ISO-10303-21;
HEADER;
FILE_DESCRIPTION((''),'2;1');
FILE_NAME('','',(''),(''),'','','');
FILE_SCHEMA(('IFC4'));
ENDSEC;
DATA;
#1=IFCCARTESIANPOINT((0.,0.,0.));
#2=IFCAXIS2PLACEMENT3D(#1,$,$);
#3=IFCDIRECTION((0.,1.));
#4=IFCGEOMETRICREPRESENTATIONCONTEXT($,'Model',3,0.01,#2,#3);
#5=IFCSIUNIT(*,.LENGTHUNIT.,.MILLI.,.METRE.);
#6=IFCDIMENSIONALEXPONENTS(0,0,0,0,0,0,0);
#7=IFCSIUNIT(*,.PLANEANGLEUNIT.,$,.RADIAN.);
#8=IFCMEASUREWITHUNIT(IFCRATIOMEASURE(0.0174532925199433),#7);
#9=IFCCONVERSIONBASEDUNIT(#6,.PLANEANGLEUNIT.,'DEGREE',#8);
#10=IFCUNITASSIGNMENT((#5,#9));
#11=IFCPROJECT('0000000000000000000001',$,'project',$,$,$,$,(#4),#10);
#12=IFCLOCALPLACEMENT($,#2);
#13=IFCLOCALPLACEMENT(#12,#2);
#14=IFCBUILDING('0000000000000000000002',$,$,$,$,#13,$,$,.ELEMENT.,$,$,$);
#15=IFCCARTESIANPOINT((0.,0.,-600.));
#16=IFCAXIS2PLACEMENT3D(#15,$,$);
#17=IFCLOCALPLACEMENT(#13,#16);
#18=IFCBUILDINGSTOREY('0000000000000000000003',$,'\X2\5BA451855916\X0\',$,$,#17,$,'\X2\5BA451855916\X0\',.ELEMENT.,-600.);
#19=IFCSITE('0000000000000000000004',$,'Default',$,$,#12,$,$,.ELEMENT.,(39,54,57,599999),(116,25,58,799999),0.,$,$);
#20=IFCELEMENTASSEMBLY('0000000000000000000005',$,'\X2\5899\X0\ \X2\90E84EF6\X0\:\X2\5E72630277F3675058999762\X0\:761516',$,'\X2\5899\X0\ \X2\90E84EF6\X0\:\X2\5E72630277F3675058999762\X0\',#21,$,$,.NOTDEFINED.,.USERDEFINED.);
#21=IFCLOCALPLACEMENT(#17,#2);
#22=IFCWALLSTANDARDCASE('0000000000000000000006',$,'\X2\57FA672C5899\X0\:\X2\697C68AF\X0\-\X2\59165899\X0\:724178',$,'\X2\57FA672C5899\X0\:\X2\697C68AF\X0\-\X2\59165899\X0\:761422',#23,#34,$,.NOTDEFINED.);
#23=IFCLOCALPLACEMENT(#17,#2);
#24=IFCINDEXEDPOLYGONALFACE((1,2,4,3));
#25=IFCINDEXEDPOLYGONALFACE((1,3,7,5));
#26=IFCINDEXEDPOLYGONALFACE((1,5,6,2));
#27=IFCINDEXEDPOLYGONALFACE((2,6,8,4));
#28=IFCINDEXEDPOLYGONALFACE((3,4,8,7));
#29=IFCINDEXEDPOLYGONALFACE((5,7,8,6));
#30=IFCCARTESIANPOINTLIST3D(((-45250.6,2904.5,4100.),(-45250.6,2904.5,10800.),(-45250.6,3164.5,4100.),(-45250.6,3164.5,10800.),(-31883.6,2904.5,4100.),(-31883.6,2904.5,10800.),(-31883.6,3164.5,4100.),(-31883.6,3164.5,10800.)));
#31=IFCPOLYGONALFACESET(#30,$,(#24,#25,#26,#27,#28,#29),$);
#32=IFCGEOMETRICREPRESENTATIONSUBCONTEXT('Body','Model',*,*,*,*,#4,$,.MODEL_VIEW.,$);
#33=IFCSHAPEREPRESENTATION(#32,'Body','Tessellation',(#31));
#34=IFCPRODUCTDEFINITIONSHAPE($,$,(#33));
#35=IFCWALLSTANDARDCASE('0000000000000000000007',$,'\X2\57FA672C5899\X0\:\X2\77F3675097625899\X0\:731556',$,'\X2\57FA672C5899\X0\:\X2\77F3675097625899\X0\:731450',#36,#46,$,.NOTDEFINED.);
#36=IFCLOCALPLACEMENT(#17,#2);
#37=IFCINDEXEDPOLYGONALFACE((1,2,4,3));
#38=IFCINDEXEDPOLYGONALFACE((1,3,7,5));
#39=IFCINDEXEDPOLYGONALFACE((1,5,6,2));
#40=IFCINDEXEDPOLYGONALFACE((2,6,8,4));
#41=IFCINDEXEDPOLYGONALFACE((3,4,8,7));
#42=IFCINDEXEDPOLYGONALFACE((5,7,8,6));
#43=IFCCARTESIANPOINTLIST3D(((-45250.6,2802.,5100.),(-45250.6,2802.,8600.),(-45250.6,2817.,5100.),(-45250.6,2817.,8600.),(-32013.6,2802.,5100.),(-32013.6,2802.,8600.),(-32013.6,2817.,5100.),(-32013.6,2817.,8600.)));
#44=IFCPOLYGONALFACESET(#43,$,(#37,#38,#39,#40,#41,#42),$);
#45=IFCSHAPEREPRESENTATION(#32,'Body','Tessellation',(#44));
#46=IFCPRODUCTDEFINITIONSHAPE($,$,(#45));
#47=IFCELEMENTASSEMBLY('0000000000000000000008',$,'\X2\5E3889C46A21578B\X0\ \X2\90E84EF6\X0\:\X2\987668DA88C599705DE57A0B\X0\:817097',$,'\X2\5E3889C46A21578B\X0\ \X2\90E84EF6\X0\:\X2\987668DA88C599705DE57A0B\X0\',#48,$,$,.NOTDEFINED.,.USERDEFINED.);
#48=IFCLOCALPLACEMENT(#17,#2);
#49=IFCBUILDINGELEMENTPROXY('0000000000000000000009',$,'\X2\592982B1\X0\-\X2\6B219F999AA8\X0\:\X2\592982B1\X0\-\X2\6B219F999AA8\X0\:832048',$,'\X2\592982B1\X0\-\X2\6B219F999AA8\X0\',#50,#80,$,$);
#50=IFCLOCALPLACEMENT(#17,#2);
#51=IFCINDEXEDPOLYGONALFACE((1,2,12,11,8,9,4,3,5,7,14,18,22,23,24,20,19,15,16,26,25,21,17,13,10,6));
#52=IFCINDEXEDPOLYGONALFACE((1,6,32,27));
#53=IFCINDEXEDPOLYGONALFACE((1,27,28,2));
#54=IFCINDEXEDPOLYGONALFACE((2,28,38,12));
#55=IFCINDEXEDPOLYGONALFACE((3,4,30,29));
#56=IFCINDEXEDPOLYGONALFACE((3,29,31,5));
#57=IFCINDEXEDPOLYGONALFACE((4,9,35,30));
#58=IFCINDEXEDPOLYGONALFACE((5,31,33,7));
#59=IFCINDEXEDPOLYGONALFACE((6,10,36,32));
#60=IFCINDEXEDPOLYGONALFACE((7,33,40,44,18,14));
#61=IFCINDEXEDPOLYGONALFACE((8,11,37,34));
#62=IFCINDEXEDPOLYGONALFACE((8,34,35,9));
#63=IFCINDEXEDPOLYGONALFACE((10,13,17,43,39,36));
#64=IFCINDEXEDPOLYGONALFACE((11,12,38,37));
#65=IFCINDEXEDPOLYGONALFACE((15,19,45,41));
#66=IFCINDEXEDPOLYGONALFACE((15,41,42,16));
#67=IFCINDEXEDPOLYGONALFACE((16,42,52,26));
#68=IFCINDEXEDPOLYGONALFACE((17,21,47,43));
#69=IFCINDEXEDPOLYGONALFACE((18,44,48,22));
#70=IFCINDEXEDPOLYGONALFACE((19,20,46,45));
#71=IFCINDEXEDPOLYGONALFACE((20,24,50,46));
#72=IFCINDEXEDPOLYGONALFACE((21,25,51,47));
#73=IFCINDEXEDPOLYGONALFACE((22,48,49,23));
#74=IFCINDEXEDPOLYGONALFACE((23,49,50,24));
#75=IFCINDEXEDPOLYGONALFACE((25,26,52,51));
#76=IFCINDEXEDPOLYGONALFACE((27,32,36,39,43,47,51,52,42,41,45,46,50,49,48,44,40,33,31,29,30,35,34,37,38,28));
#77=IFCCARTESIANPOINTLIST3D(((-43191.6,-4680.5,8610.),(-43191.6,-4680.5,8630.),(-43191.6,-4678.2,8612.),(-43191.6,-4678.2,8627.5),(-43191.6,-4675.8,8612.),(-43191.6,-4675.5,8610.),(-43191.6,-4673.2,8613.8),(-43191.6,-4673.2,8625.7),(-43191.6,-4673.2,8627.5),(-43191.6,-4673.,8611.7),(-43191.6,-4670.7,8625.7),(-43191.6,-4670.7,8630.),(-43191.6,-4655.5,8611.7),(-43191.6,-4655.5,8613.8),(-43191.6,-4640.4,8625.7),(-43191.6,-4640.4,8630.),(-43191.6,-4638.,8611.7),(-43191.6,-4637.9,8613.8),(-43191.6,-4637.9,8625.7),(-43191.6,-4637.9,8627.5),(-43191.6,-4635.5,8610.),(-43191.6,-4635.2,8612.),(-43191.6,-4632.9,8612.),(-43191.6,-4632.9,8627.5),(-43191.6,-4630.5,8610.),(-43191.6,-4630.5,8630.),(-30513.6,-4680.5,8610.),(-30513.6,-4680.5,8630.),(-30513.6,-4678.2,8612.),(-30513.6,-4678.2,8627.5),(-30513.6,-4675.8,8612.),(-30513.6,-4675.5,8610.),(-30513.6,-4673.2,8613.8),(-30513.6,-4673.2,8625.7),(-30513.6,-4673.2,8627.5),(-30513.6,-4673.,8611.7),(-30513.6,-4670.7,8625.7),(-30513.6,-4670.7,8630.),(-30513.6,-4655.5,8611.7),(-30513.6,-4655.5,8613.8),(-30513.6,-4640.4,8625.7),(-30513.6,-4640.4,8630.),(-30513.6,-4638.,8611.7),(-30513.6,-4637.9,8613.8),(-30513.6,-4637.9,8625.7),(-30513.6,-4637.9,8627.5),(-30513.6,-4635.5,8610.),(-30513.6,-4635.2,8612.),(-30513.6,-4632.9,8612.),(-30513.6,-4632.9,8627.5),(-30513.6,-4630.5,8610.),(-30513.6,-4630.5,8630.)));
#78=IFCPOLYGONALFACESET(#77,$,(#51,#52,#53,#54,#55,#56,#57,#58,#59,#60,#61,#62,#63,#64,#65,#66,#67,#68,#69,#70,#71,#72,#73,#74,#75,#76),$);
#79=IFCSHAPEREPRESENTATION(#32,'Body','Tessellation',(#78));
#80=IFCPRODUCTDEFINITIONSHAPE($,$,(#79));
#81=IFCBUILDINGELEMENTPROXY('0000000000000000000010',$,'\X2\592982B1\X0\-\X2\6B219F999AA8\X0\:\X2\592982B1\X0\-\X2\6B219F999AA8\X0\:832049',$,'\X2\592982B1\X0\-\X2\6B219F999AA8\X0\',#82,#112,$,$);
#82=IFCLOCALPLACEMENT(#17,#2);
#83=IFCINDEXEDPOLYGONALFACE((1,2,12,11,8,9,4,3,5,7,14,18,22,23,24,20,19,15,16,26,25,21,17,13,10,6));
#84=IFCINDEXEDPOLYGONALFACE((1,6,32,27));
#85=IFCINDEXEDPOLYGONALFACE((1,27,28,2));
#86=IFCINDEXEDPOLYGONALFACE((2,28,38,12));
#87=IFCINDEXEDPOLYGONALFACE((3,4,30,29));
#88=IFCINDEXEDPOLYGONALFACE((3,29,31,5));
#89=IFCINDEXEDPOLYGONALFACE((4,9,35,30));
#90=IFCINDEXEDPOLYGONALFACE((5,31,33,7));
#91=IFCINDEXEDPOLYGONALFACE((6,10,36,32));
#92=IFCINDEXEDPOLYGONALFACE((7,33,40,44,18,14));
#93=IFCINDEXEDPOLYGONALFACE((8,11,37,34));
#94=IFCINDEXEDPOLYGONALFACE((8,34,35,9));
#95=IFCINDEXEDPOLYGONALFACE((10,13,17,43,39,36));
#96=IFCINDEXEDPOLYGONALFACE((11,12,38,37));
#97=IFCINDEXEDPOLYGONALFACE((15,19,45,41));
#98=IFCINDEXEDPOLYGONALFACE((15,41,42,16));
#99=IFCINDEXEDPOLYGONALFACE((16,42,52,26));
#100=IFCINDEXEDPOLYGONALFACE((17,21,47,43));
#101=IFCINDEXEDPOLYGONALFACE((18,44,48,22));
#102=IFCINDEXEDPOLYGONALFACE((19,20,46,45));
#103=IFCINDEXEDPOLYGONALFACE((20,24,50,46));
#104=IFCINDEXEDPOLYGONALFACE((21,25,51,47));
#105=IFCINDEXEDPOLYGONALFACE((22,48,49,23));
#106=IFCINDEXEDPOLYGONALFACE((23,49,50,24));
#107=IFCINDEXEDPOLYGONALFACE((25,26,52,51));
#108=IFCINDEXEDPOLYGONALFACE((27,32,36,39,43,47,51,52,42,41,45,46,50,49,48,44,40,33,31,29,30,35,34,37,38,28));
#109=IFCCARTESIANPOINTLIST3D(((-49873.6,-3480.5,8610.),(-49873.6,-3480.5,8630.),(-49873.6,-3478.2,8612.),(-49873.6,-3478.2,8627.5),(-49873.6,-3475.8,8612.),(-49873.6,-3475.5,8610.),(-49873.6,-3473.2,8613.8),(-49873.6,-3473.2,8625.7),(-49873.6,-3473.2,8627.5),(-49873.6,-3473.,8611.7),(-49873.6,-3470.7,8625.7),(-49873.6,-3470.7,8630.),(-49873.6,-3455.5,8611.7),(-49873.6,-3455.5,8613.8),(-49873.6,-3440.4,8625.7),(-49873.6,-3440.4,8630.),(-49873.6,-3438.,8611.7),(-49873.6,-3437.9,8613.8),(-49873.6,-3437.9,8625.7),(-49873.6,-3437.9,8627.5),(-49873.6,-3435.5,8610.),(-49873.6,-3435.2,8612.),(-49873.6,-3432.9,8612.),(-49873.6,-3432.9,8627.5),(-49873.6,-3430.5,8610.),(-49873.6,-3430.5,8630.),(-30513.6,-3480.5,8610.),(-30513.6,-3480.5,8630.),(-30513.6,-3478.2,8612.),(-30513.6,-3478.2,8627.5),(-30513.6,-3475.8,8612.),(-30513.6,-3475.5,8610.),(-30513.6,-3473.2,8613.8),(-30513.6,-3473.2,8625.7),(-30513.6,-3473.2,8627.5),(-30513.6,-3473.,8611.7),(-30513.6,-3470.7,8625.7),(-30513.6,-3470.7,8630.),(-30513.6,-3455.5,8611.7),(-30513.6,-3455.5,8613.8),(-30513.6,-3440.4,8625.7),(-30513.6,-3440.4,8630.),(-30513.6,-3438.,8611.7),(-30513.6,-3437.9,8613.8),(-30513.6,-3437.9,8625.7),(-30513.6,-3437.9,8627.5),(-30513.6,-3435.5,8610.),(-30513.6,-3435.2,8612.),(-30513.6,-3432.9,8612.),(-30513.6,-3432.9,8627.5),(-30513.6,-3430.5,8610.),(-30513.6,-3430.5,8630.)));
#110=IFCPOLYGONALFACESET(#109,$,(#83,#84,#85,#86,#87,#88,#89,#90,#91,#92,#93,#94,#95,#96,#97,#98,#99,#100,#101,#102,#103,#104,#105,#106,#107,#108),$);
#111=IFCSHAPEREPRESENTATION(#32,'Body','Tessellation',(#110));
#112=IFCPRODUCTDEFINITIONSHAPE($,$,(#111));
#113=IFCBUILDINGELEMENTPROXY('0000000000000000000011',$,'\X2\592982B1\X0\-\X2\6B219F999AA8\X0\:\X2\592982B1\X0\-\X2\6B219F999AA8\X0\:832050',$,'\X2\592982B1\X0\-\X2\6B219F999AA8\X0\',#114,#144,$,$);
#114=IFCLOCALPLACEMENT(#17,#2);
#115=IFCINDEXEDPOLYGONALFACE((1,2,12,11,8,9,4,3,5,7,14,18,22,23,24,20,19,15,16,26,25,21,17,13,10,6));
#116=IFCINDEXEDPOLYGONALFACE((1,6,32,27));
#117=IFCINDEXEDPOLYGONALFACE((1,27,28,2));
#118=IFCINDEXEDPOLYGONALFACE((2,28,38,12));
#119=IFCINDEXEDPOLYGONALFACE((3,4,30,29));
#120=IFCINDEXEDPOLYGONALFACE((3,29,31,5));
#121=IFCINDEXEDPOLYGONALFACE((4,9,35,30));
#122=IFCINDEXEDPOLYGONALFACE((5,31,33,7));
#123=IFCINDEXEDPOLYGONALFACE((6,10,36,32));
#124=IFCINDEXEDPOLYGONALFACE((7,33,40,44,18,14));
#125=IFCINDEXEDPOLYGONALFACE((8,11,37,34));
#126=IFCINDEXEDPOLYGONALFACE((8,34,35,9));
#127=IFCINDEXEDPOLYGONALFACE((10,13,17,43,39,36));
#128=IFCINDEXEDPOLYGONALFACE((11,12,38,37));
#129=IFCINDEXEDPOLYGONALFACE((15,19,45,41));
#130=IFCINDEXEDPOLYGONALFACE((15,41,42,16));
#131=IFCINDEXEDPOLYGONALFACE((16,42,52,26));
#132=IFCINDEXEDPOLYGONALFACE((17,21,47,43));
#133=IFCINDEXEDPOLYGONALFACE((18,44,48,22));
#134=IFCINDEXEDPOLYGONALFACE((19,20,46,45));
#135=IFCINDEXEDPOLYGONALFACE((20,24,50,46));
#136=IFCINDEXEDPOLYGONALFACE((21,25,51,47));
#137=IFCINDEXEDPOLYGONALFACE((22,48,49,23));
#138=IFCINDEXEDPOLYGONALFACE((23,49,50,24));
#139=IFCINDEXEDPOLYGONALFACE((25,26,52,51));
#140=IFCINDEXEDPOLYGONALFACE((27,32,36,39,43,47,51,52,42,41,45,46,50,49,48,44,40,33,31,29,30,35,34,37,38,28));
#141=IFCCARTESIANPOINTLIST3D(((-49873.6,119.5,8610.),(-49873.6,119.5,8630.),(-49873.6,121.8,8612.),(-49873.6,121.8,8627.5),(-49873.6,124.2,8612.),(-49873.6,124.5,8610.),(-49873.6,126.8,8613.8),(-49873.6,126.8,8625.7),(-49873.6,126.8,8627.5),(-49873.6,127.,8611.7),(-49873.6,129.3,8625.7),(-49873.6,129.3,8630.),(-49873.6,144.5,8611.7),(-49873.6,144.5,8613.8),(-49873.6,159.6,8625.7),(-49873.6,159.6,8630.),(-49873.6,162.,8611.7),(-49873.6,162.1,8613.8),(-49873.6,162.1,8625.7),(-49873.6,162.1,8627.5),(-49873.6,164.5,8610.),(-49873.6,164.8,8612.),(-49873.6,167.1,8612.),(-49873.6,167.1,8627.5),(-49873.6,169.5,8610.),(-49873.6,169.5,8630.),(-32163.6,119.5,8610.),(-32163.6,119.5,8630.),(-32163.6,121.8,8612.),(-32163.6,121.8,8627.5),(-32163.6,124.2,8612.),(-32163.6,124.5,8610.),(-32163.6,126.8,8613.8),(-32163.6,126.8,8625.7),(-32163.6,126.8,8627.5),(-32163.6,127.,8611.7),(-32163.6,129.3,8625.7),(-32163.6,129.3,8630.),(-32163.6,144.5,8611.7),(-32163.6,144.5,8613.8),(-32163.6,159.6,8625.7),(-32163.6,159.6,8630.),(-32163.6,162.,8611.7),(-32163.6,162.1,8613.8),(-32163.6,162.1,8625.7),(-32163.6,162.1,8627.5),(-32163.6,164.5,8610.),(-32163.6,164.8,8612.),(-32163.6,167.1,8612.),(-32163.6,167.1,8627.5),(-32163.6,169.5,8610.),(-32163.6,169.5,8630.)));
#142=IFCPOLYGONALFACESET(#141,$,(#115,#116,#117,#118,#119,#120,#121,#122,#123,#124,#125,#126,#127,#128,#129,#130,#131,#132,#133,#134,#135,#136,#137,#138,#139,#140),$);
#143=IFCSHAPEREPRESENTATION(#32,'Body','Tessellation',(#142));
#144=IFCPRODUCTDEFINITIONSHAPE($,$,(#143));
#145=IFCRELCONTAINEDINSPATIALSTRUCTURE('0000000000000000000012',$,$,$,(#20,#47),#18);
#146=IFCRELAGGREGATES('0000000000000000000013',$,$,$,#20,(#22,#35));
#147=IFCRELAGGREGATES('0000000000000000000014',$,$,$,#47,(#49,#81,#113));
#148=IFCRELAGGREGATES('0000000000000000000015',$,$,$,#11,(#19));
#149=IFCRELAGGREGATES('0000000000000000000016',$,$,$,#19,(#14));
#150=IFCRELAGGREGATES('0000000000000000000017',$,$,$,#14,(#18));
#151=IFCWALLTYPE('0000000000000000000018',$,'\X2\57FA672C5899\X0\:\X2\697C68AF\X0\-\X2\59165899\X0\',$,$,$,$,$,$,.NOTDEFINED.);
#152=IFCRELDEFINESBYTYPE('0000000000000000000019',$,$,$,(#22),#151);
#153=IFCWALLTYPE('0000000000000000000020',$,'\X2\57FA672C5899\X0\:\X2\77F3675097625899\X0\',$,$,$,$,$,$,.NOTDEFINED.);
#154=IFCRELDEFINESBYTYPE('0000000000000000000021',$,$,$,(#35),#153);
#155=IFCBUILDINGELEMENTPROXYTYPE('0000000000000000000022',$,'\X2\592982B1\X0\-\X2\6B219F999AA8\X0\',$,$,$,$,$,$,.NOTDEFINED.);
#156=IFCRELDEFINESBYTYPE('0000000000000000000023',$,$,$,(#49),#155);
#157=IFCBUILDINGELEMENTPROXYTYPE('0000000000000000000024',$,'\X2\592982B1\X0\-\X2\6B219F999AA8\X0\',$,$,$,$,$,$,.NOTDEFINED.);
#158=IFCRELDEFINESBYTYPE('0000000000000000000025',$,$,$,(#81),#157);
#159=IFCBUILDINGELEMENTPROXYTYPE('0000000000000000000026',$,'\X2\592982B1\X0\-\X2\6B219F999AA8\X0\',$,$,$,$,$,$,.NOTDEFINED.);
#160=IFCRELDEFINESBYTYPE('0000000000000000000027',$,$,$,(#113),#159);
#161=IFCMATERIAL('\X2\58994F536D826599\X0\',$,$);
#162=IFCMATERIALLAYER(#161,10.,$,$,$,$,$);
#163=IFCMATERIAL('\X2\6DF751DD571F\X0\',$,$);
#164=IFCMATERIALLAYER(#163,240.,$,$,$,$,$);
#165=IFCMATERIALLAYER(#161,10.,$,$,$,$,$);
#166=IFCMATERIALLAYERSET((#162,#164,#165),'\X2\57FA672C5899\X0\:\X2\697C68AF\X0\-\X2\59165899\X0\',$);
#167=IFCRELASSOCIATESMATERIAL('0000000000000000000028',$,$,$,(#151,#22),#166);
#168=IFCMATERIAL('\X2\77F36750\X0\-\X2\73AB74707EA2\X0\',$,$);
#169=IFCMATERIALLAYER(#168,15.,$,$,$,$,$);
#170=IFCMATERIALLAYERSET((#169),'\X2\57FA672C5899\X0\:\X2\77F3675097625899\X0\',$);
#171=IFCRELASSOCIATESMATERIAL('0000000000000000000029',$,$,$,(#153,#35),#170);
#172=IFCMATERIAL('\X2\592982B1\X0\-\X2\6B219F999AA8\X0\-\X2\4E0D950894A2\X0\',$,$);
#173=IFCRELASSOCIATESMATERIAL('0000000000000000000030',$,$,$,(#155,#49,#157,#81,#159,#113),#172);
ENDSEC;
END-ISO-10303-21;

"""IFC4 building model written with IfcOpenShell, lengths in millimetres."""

from ifc_helpers import new_model, entity, si_unit, converted_unit, direction, frame, frame_2d, origin, place, context, subcontext, project, spatial, polyline, rectangle, outline, extrude, source, transform, mapped, material, layer, layer_set, layer_usage, type_object, type_shapes, element, aggregate, save


model = new_model("IFC4")

# Units and contexts
model_context = context("Model", 3, precision=0.01, world=origin(), true_north=direction((0.0, 1.0)))
body_context = subcontext(model_context, "Body", "Model", "MODEL_VIEW")
ifc_project = project(units=[si_unit("LENGTHUNIT", "METRE", prefix="MILLI"), converted_unit("PLANEANGLEUNIT", "DEGREE", entity("IfcRatioMeasure", 0.0174532925199433), si_unit("PLANEANGLEUNIT", "RADIAN"), dimensions=[0, 0, 0, 0, 0, 0, 0])], contexts=[model_context])

# Site, building, storey
site_placement = place(None, origin())
site = spatial("IfcSite", under=ifc_project, at=site_placement, Name="Default", CompositionType="ELEMENT", RefLatitude=(39, 54, 57, 599999), RefLongitude=(116, 25, 58, 799999), RefElevation=0.0)
building_placement = place(site_placement, origin())
building = spatial("IfcBuilding", under=site, at=building_placement, CompositionType="ELEMENT")
storey_placement = place(building_placement, frame((0.0, 0.0, -600.0)))
storey = spatial("IfcBuildingStorey", under=building, at=storey_placement, Name="室内外", LongName="室内外", CompositionType="ELEMENT", Elevation=-600.0)

# Element assembly, walls
assembly_1_placement = place(storey_placement, origin())
assembly_1 = element("IfcElementAssembly", 1, at=assembly_1_placement, inside=storey, Name="墙 部件:干挂石材墙面:761516", ObjectType="墙 部件:干挂石材墙面", AssemblyPlace="NOTDEFINED", PredefinedType="USERDEFINED")
ifc_material_1 = material(Name="墙体涂料")
ifc_layer_1 = layer(ifc_material_1, 10.0)
ifc_material_2 = material(Name="混凝土")
ifc_layer_2 = layer(ifc_material_2, 240.0)
ifc_layer_3 = layer(ifc_material_1, 10.0)
ifc_layer_set_1 = layer_set([ifc_layer_1, ifc_layer_2, ifc_layer_3], Name="基本墙:楼梯-外墙")
ifc_layer_usage_1 = layer_usage(ifc_layer_set_1, "AXIS2", "NEGATIVE", 130.0)
wall_type_1 = type_object("IfcWallType", Name="基本墙:楼梯-外墙", PredefinedType="NOTDEFINED", material=ifc_layer_set_1)
wall_1_placement = place(assembly_1_placement, frame((-45250.6, 3034.5, 4100.0)))
wall_1 = element("IfcWallStandardCase", 2, at=wall_1_placement, type_object=wall_type_1, material=ifc_layer_usage_1, Name="基本墙:楼梯-外墙:724178", ObjectType="基本墙:楼梯-外墙:761422", PredefinedType="NOTDEFINED", context=body_context, shape_type="SweptSolid", body=[
    extrude(rectangle(XDim=13367.0, YDim=260.0, at=frame_2d((6683.5, 0.0), x_axis=(-1.0, 0.0))), origin(), (0.0, 0.0, 1.0), 6700.0),
])
ifc_material_3 = material(Name="石材-玫瑰红")
ifc_layer_4 = layer(ifc_material_3, 15.0)
ifc_layer_set_2 = layer_set([ifc_layer_4], Name="基本墙:石材面墙")
ifc_layer_usage_2 = layer_usage(ifc_layer_set_2, "AXIS2", "POSITIVE", -7.5)
wall_type_2 = type_object("IfcWallType", Name="基本墙:石材面墙", PredefinedType="NOTDEFINED", material=ifc_layer_set_2)
wall_2_placement = place(assembly_1_placement, frame((-45250.6, 2809.5, 5100.0)))
wall_2 = element("IfcWallStandardCase", 3, at=wall_2_placement, type_object=wall_type_2, material=ifc_layer_usage_2, Name="基本墙:石材面墙:731556", ObjectType="基本墙:石材面墙:731450", PredefinedType="NOTDEFINED", context=body_context, shape_type="SweptSolid", body=[
    extrude(rectangle(XDim=13237.0, YDim=15.0, at=frame_2d((6618.5, 0.0), x_axis=(-1.0, 0.0))), origin(), (0.0, 0.0, 1.0), 3500.0),
])
aggregate(assembly_1, [wall_1, wall_2])

# Element assembly, building element proxies
assembly_2_placement = place(storey_placement, origin())
assembly_2 = element("IfcElementAssembly", 4, at=assembly_2_placement, inside=storey, Name="常规模型 部件:顶棚装饰工程:817097", ObjectType="常规模型 部件:顶棚装饰工程", AssemblyPlace="NOTDEFINED", PredefinedType="USERDEFINED")
ifc_material_4 = material(Name="天花-次龙骨-不锈钢")
building_element_proxy_type_1 = type_object("IfcBuildingElementProxyType", Name="天花-次龙骨", PredefinedType="NOTDEFINED", material=ifc_material_4)
shared_shape_1 = source(origin(), body_context, "Body", "SweptSolid", [
    extrude(outline(polyline([(-25.0, -9.1), (-20.0, -9.1), (-17.5, -7.4), (0.0, -7.4), (17.5, -7.4), (20.0, -9.1), (25.0, -9.1), (25.0, 10.9), (15.1, 10.9), (15.1, 6.6), (17.6, 6.6), (17.6, 8.4), (22.6, 8.4), (22.6, -7.1), (20.3, -7.1), (17.6, -5.3), (0.0, -5.3), (-17.6, -5.3), (-20.3, -7.1), (-22.6, -7.1), (-22.6, 8.4), (-17.6, 8.4), (-17.6, 6.6), (-15.1, 6.6), (-15.1, 10.9), (-25.0, 10.9), (-25.0, -9.1)])), frame((0.0, 0.0, -0.9), z_axis=(1.0, 0.0, 0.0), x_axis=(0.0, 1.0, 0.0)), (0.0, 0.0, 1.0), 12678.0),
])
type_shapes(building_element_proxy_type_1, [shared_shape_1])
proxy_1_placement = place(assembly_2_placement, frame((-43191.6, -4655.5, 8620.0)))
proxy_1 = element("IfcBuildingElementProxy", 5, at=proxy_1_placement, type_object=building_element_proxy_type_1, material=ifc_material_4, Name="天花-次龙骨:天花-次龙骨:832048", ObjectType="天花-次龙骨", context=body_context, shape_type="MappedRepresentation", body=[
    mapped(shared_shape_1, transform((0.0, 0.0, 0.0), scale=1.0)),
])
building_element_proxy_type_2 = type_object("IfcBuildingElementProxyType", Name="天花-次龙骨", PredefinedType="NOTDEFINED", material=ifc_material_4)
shared_shape_2 = source(origin(), body_context, "Body", "SweptSolid", [
    extrude(outline(polyline([(-25.0, -9.1), (-20.0, -9.1), (-17.5, -7.4), (0.0, -7.4), (17.5, -7.4), (20.0, -9.1), (25.0, -9.1), (25.0, 10.9), (15.1, 10.9), (15.1, 6.6), (17.6, 6.6), (17.6, 8.4), (22.6, 8.4), (22.6, -7.1), (20.3, -7.1), (17.6, -5.3), (0.0, -5.3), (-17.6, -5.3), (-20.3, -7.1), (-22.6, -7.1), (-22.6, 8.4), (-17.6, 8.4), (-17.6, 6.6), (-15.1, 6.6), (-15.1, 10.9), (-25.0, 10.9), (-25.0, -9.1)])), frame((0.0, 0.0, -0.9), z_axis=(1.0, 0.0, 0.0), x_axis=(0.0, 1.0, 0.0)), (0.0, 0.0, 1.0), 19360.0),
])
type_shapes(building_element_proxy_type_2, [shared_shape_2])
proxy_2_placement = place(assembly_2_placement, frame((-49873.6, -3455.5, 8620.0)))
proxy_2 = element("IfcBuildingElementProxy", 6, at=proxy_2_placement, type_object=building_element_proxy_type_2, material=ifc_material_4, Name="天花-次龙骨:天花-次龙骨:832049", ObjectType="天花-次龙骨", context=body_context, shape_type="MappedRepresentation", body=[
    mapped(shared_shape_2, transform((0.0, 0.0, 0.0), scale=1.0)),
])
building_element_proxy_type_3 = type_object("IfcBuildingElementProxyType", Name="天花-次龙骨", PredefinedType="NOTDEFINED", material=ifc_material_4)
shared_shape_3 = source(origin(), body_context, "Body", "SweptSolid", [
    extrude(outline(polyline([(-25.0, -9.1), (-20.0, -9.1), (-17.5, -7.4), (0.0, -7.4), (17.5, -7.4), (20.0, -9.1), (25.0, -9.1), (25.0, 10.9), (15.1, 10.9), (15.1, 6.6), (17.6, 6.6), (17.6, 8.4), (22.6, 8.4), (22.6, -7.1), (20.3, -7.1), (17.6, -5.3), (0.0, -5.3), (-17.6, -5.3), (-20.3, -7.1), (-22.6, -7.1), (-22.6, 8.4), (-17.6, 8.4), (-17.6, 6.6), (-15.1, 6.6), (-15.1, 10.9), (-25.0, 10.9), (-25.0, -9.1)])), frame((0.0, 0.0, -0.9), z_axis=(1.0, 0.0, 0.0), x_axis=(0.0, 1.0, 0.0)), (0.0, 0.0, 1.0), 17710.0),
])
type_shapes(building_element_proxy_type_3, [shared_shape_3])
proxy_3_placement = place(assembly_2_placement, frame((-49873.6, 144.5, 8620.0)))
proxy_3 = element("IfcBuildingElementProxy", 7, at=proxy_3_placement, type_object=building_element_proxy_type_3, material=ifc_material_4, Name="天花-次龙骨:天花-次龙骨:832050", ObjectType="天花-次龙骨", context=body_context, shape_type="MappedRepresentation", body=[
    mapped(shared_shape_3, transform((0.0, 0.0, 0.0), scale=1.0)),
])
aggregate(assembly_2, [proxy_1, proxy_2, proxy_3])

save(model, "model.ifc")
